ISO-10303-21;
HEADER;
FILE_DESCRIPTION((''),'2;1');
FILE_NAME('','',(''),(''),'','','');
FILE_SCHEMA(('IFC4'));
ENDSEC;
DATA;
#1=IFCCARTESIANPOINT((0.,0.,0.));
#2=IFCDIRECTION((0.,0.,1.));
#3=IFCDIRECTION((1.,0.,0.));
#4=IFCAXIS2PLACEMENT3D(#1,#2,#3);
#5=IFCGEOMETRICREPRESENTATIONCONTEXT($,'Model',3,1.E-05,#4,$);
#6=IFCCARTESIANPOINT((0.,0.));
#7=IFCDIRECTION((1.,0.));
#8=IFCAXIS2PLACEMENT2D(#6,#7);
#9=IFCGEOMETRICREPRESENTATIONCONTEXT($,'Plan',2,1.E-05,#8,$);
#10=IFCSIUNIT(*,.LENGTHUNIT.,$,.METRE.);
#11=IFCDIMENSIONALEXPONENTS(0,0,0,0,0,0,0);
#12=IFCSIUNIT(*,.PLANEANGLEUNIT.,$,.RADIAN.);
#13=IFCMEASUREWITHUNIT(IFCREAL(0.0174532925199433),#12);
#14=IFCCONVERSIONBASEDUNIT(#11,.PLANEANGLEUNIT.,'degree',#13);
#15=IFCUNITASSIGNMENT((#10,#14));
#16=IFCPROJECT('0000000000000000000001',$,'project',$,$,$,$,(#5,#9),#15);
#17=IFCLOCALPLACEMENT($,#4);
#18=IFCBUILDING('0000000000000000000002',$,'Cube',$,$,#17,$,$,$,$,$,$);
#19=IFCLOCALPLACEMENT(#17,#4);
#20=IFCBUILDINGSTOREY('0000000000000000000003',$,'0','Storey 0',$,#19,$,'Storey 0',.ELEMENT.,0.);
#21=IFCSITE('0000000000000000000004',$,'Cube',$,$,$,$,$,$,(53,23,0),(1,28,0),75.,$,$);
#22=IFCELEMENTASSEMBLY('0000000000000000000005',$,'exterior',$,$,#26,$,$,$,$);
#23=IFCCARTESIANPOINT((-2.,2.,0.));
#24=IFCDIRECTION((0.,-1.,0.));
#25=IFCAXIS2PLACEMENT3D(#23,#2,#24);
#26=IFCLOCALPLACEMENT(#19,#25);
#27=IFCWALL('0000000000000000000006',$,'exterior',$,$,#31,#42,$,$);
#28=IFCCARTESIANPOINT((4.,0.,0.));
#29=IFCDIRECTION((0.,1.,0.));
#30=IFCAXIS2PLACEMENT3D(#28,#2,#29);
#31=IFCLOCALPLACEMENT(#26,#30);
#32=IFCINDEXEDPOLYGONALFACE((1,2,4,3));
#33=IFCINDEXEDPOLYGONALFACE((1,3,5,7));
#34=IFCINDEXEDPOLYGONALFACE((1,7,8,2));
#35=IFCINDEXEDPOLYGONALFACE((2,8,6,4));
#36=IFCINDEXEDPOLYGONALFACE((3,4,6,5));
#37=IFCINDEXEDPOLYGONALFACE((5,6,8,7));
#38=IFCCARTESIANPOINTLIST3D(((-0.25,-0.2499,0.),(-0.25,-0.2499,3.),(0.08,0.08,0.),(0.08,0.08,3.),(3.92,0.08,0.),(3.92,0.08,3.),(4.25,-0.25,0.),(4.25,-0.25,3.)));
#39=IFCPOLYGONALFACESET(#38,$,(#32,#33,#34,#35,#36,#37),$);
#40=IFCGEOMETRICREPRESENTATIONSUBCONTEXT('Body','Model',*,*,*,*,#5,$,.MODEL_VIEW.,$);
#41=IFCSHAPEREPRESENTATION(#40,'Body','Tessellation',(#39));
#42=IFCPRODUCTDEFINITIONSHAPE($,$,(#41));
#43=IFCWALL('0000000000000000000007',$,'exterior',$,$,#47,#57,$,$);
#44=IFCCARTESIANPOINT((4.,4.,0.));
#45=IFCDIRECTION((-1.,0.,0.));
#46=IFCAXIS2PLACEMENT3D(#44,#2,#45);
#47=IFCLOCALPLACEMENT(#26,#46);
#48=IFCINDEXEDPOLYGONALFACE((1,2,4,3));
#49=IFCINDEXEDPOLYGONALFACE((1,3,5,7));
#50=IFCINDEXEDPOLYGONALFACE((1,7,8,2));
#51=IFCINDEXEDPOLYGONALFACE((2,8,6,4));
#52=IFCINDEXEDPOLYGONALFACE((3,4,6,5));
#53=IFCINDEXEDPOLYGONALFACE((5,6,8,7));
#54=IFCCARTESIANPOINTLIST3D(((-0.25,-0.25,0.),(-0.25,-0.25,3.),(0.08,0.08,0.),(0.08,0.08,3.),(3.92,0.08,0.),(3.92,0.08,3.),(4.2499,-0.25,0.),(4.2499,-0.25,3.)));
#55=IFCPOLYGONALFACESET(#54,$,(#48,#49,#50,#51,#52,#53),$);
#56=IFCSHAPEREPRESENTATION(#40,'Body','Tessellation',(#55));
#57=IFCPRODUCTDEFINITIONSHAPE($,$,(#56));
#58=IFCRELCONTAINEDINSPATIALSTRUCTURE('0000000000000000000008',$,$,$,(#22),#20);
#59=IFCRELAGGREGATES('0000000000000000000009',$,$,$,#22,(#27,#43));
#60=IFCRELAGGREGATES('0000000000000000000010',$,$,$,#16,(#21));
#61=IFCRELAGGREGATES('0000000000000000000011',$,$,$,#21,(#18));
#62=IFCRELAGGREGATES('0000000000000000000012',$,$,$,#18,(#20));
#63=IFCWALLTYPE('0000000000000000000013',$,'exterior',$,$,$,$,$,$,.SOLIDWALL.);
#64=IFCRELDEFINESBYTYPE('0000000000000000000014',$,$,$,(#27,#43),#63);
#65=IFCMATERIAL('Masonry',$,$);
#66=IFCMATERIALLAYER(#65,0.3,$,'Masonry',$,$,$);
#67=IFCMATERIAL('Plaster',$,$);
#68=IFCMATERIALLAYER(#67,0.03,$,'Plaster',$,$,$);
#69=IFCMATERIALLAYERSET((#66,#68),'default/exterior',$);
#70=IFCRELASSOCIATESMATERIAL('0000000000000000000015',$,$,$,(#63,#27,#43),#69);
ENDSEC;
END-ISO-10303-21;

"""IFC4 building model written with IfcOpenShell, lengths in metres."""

from ifc_helpers import new_model, entity, si_unit, converted_unit, frame, origin, origin_with_axes, origin_2d_with_axis, place, context, subcontext, project, spatial, polyline, outline, extrude, material, layer, layer_set, layer_usage, type_object, element, aggregate, save


model = new_model("IFC4")

# Units and contexts
model_context = context("Model", 3, precision=1e-05, world=origin_with_axes())
plan_context = context("Plan", 2, precision=1e-05, world=origin_2d_with_axis())
body_context = subcontext(model_context, "Body", "Model", "MODEL_VIEW")
ifc_project = project(units=[si_unit("LENGTHUNIT", "METRE"), converted_unit("PLANEANGLEUNIT", "degree", entity("IfcReal", 0.0174532925199433), si_unit("PLANEANGLEUNIT", "RADIAN"), dimensions=[0, 0, 0, 0, 0, 0, 0])], contexts=[model_context, plan_context])

# Site, building, storey
site = spatial("IfcSite", under=ifc_project, Name="Cube", RefLatitude=(53, 23, 0), RefLongitude=(1, 28, 0), RefElevation=75.0)
building_placement = place(None, origin_with_axes())
building = spatial("IfcBuilding", under=site, at=building_placement, Name="Cube")
storey_placement = place(building_placement, origin_with_axes())
storey = spatial("IfcBuildingStorey", under=building, at=storey_placement, Name="0", Description="Storey 0", LongName="Storey 0", CompositionType="ELEMENT", Elevation=0.0)

# Element assembly, walls
assembly_1_placement = place(storey_placement, frame((-2.0, 2.0, 0.0), z_axis=(0.0, 0.0, 1.0), x_axis=(0.0, -1.0, 0.0)))
assembly_1 = element("IfcElementAssembly", 1, at=assembly_1_placement, inside=storey, Name="exterior")
ifc_material_1 = material(Name="Masonry")
ifc_layer_1 = layer(ifc_material_1, 0.3, Name="Masonry")
ifc_material_2 = material(Name="Plaster")
ifc_layer_2 = layer(ifc_material_2, 0.03, Name="Plaster")
ifc_layer_set_1 = layer_set([ifc_layer_1, ifc_layer_2], Name="default/exterior")
ifc_layer_usage_1 = layer_usage(ifc_layer_set_1, "AXIS2", "POSITIVE", -0.25)
wall_type = type_object("IfcWallType", Name="exterior", PredefinedType="SOLIDWALL", material=ifc_layer_set_1)
wall_1_placement = place(assembly_1_placement, frame((4.0, 0.0, 0.0), z_axis=(0.0, 0.0, 1.0), x_axis=(0.0, 1.0, 0.0)))
wall_1 = element("IfcWall", 2, at=wall_1_placement, type_object=wall_type, material=ifc_layer_usage_1, Name="exterior", context=body_context, shape_type="SweptSolid", body=[
    extrude(outline(polyline([(0.08, 0.08), (-0.25, -0.2499), (4.25, -0.25), (3.92, 0.08), (0.08, 0.08)])), origin(), (0.0, 0.0, 1.0), 3.0),
])
ifc_layer_usage_2 = layer_usage(ifc_layer_set_1, "AXIS2", "POSITIVE", -0.25)
wall_2_placement = place(assembly_1_placement, frame((4.0, 4.0, 0.0), z_axis=(0.0, 0.0, 1.0), x_axis=(-1.0, 0.0, 0.0)))
wall_2 = element("IfcWall", 3, at=wall_2_placement, type_object=wall_type, material=ifc_layer_usage_2, Name="exterior", context=body_context, shape_type="SweptSolid", body=[
    extrude(outline(polyline([(0.08, 0.08), (-0.25, -0.25), (4.2499, -0.25), (3.92, 0.08), (0.08, 0.08)])), origin(), (0.0, 0.0, 1.0), 3.0),
])
aggregate(assembly_1, [wall_1, wall_2])

save(model, "model.ifc")
